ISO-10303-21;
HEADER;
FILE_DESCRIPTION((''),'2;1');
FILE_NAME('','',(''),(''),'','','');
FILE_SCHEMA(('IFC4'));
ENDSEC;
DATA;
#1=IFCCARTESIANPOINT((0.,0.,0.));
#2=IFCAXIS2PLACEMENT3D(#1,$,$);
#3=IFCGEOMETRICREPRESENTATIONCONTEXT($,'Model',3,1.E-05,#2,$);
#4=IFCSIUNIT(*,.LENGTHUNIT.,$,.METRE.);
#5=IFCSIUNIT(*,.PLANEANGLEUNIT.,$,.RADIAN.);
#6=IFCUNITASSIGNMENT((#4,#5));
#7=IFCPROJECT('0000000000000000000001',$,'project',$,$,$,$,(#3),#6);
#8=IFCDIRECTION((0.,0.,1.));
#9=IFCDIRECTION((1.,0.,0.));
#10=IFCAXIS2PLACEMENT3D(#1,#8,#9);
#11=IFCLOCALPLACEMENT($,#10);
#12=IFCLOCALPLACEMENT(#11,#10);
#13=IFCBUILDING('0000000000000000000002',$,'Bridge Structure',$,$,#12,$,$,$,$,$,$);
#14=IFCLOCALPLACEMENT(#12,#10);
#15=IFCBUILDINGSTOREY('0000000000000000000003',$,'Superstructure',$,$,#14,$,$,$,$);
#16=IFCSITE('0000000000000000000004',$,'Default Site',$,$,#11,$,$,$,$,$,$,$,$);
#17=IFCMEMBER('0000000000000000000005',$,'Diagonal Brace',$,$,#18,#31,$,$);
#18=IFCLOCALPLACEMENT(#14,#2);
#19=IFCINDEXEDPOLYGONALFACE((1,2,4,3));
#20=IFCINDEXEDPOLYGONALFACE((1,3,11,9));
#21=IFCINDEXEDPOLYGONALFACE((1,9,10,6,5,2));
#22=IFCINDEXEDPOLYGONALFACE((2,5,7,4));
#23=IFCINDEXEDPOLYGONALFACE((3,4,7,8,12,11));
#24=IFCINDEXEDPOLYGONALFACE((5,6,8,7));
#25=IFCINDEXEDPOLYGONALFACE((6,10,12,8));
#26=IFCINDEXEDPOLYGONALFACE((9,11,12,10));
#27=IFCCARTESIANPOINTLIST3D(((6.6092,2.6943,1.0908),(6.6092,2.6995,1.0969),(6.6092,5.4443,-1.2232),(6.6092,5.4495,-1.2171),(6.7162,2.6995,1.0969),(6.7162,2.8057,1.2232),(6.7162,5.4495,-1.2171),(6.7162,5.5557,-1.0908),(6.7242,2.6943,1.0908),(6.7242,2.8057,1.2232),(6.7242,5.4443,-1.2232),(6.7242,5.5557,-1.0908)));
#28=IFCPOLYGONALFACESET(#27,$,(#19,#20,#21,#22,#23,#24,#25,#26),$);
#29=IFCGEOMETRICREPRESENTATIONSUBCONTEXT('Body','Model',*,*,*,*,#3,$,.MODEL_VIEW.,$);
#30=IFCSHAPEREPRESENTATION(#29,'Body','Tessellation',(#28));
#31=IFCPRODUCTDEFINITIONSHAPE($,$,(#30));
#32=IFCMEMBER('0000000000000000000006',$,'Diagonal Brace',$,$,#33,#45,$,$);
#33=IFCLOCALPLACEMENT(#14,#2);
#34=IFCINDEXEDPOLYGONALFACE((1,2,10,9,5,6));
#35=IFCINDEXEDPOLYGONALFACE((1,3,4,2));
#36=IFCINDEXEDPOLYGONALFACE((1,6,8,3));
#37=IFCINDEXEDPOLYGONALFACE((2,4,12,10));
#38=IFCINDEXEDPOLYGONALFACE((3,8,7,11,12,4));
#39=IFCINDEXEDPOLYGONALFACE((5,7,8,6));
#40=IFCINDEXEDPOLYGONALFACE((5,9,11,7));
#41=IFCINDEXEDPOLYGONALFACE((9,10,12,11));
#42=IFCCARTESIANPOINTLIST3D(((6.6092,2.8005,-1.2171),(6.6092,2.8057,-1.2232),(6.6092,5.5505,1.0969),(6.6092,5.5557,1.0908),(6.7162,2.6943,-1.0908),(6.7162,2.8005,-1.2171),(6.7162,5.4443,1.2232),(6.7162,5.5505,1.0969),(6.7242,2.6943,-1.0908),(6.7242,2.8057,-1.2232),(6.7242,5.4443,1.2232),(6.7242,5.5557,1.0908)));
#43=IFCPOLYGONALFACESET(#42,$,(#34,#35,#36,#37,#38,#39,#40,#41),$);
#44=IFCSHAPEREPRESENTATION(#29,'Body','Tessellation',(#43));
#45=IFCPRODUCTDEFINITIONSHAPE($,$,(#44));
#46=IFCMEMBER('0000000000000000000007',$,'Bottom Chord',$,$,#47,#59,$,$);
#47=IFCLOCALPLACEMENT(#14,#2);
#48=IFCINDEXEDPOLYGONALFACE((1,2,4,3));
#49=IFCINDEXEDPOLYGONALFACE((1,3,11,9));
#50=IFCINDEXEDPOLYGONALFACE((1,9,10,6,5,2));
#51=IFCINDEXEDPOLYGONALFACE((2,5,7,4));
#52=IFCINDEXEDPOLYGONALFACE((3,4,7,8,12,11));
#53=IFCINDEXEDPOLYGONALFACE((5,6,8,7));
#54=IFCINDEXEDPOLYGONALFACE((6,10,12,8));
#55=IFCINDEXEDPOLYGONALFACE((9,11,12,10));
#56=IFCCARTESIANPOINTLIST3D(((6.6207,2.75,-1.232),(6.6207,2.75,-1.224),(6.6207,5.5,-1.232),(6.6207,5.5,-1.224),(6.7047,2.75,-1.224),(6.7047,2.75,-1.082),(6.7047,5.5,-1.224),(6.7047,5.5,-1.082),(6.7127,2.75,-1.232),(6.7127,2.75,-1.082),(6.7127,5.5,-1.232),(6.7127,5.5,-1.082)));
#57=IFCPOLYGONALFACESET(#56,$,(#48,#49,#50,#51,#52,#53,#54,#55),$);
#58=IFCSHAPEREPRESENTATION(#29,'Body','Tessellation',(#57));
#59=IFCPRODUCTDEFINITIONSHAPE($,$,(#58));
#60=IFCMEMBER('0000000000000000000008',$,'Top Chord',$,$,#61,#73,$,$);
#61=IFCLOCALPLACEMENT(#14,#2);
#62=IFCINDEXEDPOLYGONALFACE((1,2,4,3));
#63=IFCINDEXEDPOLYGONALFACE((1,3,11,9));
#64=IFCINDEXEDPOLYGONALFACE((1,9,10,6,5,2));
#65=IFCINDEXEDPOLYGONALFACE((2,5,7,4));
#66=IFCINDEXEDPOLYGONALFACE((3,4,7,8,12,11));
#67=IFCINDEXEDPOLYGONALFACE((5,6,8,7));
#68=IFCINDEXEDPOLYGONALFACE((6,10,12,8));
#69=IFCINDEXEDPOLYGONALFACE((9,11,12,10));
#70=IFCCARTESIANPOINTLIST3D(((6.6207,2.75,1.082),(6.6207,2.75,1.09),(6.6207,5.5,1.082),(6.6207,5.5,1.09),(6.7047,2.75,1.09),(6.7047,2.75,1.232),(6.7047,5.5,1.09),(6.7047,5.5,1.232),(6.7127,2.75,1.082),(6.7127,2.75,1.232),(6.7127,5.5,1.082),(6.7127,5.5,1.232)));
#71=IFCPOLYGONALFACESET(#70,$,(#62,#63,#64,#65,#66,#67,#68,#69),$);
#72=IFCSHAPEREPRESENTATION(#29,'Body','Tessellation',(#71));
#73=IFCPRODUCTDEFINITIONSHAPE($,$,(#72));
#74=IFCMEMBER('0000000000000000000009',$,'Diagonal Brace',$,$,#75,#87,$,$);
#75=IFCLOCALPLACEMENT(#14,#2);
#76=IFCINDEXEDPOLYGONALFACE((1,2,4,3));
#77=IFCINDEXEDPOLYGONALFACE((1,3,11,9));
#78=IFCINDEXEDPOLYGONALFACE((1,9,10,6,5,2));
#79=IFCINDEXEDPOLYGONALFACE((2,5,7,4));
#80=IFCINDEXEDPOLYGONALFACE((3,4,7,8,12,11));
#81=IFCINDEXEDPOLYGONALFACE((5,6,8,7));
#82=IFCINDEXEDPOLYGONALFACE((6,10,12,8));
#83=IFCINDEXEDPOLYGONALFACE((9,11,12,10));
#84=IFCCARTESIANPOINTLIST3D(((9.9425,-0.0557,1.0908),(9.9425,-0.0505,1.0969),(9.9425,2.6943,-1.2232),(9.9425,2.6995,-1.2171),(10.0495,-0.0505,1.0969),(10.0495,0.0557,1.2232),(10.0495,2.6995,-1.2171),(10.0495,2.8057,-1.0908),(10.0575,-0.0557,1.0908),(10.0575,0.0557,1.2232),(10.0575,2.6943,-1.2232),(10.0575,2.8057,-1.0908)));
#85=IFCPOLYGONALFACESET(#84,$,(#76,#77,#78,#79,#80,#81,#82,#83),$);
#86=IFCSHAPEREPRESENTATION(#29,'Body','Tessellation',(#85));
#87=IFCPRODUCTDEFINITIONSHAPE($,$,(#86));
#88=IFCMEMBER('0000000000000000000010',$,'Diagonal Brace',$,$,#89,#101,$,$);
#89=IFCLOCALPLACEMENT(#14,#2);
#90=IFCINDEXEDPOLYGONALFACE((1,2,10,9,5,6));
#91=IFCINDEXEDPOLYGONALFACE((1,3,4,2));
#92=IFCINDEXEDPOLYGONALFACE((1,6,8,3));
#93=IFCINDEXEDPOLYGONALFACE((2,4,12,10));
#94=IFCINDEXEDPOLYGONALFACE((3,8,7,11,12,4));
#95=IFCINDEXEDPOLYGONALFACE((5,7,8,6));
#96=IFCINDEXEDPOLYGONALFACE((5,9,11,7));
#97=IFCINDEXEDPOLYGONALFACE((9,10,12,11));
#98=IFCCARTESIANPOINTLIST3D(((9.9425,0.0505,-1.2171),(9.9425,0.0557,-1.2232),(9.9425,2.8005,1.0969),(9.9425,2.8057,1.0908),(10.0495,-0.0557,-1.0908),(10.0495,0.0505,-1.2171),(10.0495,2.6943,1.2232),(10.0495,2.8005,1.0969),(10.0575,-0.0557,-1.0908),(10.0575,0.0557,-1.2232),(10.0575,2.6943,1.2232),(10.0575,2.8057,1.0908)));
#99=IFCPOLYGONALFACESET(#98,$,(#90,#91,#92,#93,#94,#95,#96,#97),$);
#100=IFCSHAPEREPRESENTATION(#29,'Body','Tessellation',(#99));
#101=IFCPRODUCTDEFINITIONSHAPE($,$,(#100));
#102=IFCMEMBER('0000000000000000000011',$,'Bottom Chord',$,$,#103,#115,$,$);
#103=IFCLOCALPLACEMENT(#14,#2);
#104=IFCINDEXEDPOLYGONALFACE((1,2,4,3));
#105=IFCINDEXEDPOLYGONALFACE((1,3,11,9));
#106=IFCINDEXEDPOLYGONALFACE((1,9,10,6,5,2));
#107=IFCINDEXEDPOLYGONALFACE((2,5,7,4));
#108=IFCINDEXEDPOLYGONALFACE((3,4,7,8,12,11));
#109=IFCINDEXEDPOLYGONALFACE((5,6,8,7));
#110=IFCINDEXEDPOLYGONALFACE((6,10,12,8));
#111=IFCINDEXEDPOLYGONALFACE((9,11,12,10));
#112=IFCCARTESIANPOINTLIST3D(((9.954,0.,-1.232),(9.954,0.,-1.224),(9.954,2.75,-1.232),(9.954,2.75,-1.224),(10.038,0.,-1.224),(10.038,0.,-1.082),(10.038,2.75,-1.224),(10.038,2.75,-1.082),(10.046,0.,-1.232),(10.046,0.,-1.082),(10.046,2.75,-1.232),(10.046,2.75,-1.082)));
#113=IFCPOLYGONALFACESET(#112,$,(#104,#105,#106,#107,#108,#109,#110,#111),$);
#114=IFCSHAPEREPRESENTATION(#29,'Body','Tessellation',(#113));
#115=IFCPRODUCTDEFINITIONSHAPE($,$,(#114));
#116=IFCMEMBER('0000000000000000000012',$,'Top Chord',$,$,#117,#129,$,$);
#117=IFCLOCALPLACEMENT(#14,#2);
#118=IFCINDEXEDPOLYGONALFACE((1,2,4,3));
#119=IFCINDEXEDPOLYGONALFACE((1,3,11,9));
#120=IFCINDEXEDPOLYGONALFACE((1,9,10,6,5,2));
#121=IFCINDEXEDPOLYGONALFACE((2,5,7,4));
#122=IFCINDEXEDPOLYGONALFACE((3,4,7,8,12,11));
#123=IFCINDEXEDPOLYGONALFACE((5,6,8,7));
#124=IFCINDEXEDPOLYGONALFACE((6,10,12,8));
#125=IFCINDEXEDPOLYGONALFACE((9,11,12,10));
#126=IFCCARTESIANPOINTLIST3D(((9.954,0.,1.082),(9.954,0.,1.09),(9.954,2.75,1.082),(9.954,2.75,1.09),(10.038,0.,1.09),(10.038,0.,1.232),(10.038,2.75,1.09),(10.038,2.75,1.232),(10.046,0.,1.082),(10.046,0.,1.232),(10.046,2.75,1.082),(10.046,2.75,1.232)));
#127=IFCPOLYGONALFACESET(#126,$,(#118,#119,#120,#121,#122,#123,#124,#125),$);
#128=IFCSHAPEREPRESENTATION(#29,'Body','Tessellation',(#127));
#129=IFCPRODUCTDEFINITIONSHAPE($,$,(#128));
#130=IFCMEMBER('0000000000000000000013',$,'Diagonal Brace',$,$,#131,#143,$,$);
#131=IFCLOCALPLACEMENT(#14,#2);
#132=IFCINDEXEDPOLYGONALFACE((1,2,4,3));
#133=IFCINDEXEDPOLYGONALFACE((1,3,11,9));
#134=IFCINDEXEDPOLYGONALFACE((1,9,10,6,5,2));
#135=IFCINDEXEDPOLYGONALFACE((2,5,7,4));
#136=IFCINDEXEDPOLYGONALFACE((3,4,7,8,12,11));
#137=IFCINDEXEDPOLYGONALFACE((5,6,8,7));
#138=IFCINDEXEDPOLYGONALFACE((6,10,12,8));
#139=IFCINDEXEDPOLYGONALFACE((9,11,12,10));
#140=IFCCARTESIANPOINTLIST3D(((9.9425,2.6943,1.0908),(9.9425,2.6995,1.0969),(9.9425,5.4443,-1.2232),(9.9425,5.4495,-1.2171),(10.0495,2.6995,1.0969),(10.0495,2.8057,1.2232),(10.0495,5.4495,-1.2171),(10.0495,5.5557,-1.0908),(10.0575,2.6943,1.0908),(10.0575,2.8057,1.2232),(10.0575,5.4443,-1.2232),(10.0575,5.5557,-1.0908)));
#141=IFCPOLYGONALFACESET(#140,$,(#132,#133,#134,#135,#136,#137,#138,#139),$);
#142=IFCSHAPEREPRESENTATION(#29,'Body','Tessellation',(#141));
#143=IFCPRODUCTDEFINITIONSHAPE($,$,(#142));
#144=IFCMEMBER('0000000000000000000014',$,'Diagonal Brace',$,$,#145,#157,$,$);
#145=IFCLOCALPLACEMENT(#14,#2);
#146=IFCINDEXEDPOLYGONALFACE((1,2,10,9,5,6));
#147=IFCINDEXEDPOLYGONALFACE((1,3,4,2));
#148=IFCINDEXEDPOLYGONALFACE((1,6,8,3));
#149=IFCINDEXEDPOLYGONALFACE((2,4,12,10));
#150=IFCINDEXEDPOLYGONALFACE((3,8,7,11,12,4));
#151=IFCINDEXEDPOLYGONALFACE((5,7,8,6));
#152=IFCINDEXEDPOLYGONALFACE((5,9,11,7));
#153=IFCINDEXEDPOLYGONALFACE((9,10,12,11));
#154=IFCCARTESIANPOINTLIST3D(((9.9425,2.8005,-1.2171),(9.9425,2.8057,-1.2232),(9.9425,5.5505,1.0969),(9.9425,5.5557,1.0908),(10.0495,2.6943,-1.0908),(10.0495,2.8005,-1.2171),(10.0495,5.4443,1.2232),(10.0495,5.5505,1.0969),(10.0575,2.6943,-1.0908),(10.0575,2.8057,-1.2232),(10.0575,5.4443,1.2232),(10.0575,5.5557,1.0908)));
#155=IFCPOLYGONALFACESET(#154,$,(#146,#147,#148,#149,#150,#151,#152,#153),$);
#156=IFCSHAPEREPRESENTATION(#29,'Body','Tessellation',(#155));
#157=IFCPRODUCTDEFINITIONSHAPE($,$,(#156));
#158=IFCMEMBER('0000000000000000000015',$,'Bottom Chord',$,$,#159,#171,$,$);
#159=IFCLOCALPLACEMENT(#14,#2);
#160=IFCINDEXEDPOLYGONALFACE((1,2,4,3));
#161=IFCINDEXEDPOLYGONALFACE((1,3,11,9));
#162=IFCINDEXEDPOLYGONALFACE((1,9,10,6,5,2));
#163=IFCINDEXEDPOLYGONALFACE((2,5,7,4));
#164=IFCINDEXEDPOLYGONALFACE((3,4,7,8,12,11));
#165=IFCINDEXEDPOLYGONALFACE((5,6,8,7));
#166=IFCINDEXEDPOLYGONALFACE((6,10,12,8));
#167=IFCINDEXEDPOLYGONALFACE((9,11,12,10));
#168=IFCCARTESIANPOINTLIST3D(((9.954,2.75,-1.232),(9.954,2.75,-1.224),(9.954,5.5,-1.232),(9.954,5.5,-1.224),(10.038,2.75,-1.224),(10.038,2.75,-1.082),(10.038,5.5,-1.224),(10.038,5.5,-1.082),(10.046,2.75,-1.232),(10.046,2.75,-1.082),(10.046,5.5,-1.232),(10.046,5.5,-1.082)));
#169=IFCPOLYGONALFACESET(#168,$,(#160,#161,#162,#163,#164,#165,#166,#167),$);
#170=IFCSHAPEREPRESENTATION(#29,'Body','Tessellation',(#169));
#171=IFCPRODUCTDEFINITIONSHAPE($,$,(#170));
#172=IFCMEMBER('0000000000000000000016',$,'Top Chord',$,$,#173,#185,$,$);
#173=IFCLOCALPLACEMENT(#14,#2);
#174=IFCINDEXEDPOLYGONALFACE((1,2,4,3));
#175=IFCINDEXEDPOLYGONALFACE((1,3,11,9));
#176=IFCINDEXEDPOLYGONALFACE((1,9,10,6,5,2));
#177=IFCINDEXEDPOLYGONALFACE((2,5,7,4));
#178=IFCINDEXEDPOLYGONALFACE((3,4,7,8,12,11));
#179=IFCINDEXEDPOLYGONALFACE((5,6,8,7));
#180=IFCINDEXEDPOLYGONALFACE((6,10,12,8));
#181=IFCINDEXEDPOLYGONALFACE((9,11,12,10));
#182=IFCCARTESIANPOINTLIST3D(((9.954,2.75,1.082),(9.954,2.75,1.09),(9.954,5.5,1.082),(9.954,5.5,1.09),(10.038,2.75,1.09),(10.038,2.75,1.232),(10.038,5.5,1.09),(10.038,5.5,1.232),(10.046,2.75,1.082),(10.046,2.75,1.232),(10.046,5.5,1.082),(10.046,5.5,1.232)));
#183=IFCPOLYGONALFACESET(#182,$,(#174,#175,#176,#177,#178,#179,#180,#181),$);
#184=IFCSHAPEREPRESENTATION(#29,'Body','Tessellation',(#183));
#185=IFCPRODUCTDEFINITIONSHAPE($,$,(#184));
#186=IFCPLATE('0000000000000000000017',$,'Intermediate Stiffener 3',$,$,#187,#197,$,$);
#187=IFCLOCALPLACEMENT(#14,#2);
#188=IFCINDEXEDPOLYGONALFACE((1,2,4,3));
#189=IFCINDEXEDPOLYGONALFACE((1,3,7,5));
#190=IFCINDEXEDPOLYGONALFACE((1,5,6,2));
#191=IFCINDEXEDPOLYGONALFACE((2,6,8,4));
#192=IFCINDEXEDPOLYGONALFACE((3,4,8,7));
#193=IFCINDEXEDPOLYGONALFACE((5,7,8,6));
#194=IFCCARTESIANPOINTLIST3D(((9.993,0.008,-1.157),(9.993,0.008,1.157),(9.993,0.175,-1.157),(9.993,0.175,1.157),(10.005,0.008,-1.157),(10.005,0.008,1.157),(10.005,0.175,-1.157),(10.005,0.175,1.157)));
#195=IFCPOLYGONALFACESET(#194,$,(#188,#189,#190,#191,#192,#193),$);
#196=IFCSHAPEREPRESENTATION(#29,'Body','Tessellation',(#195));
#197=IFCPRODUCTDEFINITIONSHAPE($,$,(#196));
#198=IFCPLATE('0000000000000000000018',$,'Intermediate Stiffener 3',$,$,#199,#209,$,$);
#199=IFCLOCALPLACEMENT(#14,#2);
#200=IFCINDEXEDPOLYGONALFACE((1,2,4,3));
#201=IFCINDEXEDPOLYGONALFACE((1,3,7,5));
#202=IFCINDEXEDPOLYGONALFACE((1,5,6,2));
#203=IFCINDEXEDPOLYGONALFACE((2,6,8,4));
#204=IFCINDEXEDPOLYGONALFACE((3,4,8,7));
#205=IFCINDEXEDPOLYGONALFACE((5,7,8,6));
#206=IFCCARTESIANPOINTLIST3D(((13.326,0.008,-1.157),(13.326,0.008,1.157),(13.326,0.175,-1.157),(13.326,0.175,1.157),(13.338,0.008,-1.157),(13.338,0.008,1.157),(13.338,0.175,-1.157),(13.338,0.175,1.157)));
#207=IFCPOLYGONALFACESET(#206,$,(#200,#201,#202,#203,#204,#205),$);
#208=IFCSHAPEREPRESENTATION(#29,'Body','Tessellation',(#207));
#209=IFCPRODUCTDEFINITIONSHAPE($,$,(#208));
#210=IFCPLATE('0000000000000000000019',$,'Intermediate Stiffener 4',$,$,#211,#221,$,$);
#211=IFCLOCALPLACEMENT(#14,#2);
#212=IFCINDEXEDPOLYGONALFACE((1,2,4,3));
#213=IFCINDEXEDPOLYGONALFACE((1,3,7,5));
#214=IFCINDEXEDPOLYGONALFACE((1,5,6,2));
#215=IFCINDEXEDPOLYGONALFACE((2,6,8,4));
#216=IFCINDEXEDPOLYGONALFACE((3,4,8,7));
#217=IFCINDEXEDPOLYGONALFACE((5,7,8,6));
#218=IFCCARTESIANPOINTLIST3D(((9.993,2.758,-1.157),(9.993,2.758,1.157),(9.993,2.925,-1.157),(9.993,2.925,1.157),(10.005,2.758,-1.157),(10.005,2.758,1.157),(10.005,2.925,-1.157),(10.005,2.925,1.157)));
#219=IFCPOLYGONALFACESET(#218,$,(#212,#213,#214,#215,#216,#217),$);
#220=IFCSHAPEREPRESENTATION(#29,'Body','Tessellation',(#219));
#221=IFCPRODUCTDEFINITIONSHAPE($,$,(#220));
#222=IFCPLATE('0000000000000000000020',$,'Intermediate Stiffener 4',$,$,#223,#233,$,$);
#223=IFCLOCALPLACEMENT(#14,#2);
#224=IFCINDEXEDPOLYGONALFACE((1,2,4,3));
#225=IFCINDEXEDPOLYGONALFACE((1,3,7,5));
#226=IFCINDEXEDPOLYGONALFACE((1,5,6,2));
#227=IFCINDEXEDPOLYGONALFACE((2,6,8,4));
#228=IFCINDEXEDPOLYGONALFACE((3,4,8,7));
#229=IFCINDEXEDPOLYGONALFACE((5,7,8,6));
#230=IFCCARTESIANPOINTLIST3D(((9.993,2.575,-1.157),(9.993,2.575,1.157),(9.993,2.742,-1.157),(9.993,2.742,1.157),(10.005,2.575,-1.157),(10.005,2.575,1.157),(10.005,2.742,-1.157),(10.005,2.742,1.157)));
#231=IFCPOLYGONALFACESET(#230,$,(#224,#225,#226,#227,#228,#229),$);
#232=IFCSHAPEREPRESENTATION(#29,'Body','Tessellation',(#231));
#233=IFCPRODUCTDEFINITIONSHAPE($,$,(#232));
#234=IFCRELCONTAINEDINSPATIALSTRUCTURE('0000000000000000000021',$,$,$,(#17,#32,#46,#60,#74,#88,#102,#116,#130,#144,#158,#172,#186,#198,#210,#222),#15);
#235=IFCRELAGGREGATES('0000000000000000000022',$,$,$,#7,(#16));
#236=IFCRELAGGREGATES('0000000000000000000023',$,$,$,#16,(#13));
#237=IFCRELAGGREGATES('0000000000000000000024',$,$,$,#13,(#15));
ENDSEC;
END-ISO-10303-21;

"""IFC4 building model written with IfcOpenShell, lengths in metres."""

from ifc_helpers import new_model, si_unit, frame, origin, origin_with_axes, origin_2d_with_axis, place, context, subcontext, project, spatial, rectangle, l_section, extrude, element, save


model = new_model("IFC4")

# Units and contexts
model_context = context("Model", 3, precision=1e-05, world=origin())
body_context = subcontext(model_context, "Body", "Model", "MODEL_VIEW")
ifc_project = project(units=[si_unit("LENGTHUNIT", "METRE"), si_unit("PLANEANGLEUNIT", "RADIAN")], contexts=[model_context])

# Site, building, storey
site_placement = place(None, origin_with_axes())
site = spatial("IfcSite", under=ifc_project, at=site_placement, Name="Default Site")
building_placement = place(site_placement, origin_with_axes())
building = spatial("IfcBuilding", under=site, at=building_placement, Name="Bridge Structure")
storey_placement = place(building_placement, origin_with_axes())
storey = spatial("IfcBuildingStorey", under=building, at=storey_placement, Name="Superstructure")

# Members
for number, where, z_axis, x_axis, name in (
    (1, (6.6667, 2.75, 1.157), (0.0, 0.765156, -0.643844), (-1.0, 0.0, 0.0), "Diagonal Brace"),
    (2, (6.6667, 2.75, -1.157), (0.0, 0.765156, 0.643844), (-1.0, 0.0, 0.0), "Diagonal Brace"),
):
    element("IfcMember", number, at=place(storey_placement, frame(where, z_axis=z_axis, x_axis=x_axis)), inside=storey, Name=name, context=body_context, shape_type="SweptSolid", body=[
        extrude(l_section(Depth=0.173, Width=0.115, Thickness=0.008, at=origin_2d_with_axis()), origin_with_axes(), (0.0, 0.0, 1.0), 3.594),
    ])
for number, where, z_axis, x_axis, name in (
    (3, (6.6667, 2.75, -1.157), (0.0, 1.0, 0.0), (-1.0, 0.0, 0.0), "Bottom Chord"),
    (4, (6.6667, 2.75, 1.157), (0.0, 1.0, 0.0), (-1.0, 0.0, 0.0), "Top Chord"),
):
    element("IfcMember", number, at=place(storey_placement, frame(where, z_axis=z_axis, x_axis=x_axis)), inside=storey, Name=name, context=body_context, shape_type="SweptSolid", body=[
        extrude(l_section(Depth=0.15, Width=0.092, Thickness=0.008, at=origin_2d_with_axis()), origin_with_axes(), (0.0, 0.0, 1.0), 2.75),
    ])
for number, where, z_axis, x_axis, name in (
    (5, (10.0, 0.0, 1.157), (0.0, 0.765156, -0.643844), (-1.0, 0.0, 0.0), "Diagonal Brace"),
    (6, (10.0, 0.0, -1.157), (0.0, 0.765156, 0.643844), (-1.0, 0.0, 0.0), "Diagonal Brace"),
):
    element("IfcMember", number, at=place(storey_placement, frame(where, z_axis=z_axis, x_axis=x_axis)), inside=storey, Name=name, context=body_context, shape_type="SweptSolid", body=[
        extrude(l_section(Depth=0.173, Width=0.115, Thickness=0.008, at=origin_2d_with_axis()), origin_with_axes(), (0.0, 0.0, 1.0), 3.594),
    ])
for number, where, z_axis, x_axis, name in (
    (7, (10.0, 0.0, -1.157), (0.0, 1.0, 0.0), (-1.0, 0.0, 0.0), "Bottom Chord"),
    (8, (10.0, 0.0, 1.157), (0.0, 1.0, 0.0), (-1.0, 0.0, 0.0), "Top Chord"),
):
    element("IfcMember", number, at=place(storey_placement, frame(where, z_axis=z_axis, x_axis=x_axis)), inside=storey, Name=name, context=body_context, shape_type="SweptSolid", body=[
        extrude(l_section(Depth=0.15, Width=0.092, Thickness=0.008, at=origin_2d_with_axis()), origin_with_axes(), (0.0, 0.0, 1.0), 2.75),
    ])
for number, where, z_axis, x_axis, name in (
    (9, (10.0, 2.75, 1.157), (0.0, 0.765156, -0.643844), (-1.0, 0.0, 0.0), "Diagonal Brace"),
    (10, (10.0, 2.75, -1.157), (0.0, 0.765156, 0.643844), (-1.0, 0.0, 0.0), "Diagonal Brace"),
):
    element("IfcMember", number, at=place(storey_placement, frame(where, z_axis=z_axis, x_axis=x_axis)), inside=storey, Name=name, context=body_context, shape_type="SweptSolid", body=[
        extrude(l_section(Depth=0.173, Width=0.115, Thickness=0.008, at=origin_2d_with_axis()), origin_with_axes(), (0.0, 0.0, 1.0), 3.594),
    ])
for number, where, z_axis, x_axis, name in (
    (11, (10.0, 2.75, -1.157), (0.0, 1.0, 0.0), (-1.0, 0.0, 0.0), "Bottom Chord"),
    (12, (10.0, 2.75, 1.157), (0.0, 1.0, 0.0), (-1.0, 0.0, 0.0), "Top Chord"),
):
    element("IfcMember", number, at=place(storey_placement, frame(where, z_axis=z_axis, x_axis=x_axis)), inside=storey, Name=name, context=body_context, shape_type="SweptSolid", body=[
        extrude(l_section(Depth=0.15, Width=0.092, Thickness=0.008, at=origin_2d_with_axis()), origin_with_axes(), (0.0, 0.0, 1.0), 2.75),
    ])

# Plates
for number, where, z_axis, x_axis, name in (
    (13, (9.999, 0.0915, -1.157), (0.0, 0.0, 1.0), (1.0, 0.0, 0.0), "Intermediate Stiffener 3"),
    (14, (13.332, 0.0915, -1.157), (0.0, 0.0, 1.0), (1.0, 0.0, 0.0), "Intermediate Stiffener 3"),
    (15, (9.999, 2.8415, -1.157), (0.0, 0.0, 1.0), (1.0, 0.0, 0.0), "Intermediate Stiffener 4"),
    (16, (9.999, 2.6585, -1.157), (0.0, 0.0, 1.0), (1.0, 0.0, 0.0), "Intermediate Stiffener 4"),
):
    element("IfcPlate", number, at=place(storey_placement, frame(where, z_axis=z_axis, x_axis=x_axis)), inside=storey, Name=name, context=body_context, shape_type="SweptSolid", body=[
        extrude(rectangle(XDim=0.012, YDim=0.167, at=origin_2d_with_axis()), origin_with_axes(), (0.0, 0.0, 1.0), 2.314),
    ])

save(model, "model.ifc")
